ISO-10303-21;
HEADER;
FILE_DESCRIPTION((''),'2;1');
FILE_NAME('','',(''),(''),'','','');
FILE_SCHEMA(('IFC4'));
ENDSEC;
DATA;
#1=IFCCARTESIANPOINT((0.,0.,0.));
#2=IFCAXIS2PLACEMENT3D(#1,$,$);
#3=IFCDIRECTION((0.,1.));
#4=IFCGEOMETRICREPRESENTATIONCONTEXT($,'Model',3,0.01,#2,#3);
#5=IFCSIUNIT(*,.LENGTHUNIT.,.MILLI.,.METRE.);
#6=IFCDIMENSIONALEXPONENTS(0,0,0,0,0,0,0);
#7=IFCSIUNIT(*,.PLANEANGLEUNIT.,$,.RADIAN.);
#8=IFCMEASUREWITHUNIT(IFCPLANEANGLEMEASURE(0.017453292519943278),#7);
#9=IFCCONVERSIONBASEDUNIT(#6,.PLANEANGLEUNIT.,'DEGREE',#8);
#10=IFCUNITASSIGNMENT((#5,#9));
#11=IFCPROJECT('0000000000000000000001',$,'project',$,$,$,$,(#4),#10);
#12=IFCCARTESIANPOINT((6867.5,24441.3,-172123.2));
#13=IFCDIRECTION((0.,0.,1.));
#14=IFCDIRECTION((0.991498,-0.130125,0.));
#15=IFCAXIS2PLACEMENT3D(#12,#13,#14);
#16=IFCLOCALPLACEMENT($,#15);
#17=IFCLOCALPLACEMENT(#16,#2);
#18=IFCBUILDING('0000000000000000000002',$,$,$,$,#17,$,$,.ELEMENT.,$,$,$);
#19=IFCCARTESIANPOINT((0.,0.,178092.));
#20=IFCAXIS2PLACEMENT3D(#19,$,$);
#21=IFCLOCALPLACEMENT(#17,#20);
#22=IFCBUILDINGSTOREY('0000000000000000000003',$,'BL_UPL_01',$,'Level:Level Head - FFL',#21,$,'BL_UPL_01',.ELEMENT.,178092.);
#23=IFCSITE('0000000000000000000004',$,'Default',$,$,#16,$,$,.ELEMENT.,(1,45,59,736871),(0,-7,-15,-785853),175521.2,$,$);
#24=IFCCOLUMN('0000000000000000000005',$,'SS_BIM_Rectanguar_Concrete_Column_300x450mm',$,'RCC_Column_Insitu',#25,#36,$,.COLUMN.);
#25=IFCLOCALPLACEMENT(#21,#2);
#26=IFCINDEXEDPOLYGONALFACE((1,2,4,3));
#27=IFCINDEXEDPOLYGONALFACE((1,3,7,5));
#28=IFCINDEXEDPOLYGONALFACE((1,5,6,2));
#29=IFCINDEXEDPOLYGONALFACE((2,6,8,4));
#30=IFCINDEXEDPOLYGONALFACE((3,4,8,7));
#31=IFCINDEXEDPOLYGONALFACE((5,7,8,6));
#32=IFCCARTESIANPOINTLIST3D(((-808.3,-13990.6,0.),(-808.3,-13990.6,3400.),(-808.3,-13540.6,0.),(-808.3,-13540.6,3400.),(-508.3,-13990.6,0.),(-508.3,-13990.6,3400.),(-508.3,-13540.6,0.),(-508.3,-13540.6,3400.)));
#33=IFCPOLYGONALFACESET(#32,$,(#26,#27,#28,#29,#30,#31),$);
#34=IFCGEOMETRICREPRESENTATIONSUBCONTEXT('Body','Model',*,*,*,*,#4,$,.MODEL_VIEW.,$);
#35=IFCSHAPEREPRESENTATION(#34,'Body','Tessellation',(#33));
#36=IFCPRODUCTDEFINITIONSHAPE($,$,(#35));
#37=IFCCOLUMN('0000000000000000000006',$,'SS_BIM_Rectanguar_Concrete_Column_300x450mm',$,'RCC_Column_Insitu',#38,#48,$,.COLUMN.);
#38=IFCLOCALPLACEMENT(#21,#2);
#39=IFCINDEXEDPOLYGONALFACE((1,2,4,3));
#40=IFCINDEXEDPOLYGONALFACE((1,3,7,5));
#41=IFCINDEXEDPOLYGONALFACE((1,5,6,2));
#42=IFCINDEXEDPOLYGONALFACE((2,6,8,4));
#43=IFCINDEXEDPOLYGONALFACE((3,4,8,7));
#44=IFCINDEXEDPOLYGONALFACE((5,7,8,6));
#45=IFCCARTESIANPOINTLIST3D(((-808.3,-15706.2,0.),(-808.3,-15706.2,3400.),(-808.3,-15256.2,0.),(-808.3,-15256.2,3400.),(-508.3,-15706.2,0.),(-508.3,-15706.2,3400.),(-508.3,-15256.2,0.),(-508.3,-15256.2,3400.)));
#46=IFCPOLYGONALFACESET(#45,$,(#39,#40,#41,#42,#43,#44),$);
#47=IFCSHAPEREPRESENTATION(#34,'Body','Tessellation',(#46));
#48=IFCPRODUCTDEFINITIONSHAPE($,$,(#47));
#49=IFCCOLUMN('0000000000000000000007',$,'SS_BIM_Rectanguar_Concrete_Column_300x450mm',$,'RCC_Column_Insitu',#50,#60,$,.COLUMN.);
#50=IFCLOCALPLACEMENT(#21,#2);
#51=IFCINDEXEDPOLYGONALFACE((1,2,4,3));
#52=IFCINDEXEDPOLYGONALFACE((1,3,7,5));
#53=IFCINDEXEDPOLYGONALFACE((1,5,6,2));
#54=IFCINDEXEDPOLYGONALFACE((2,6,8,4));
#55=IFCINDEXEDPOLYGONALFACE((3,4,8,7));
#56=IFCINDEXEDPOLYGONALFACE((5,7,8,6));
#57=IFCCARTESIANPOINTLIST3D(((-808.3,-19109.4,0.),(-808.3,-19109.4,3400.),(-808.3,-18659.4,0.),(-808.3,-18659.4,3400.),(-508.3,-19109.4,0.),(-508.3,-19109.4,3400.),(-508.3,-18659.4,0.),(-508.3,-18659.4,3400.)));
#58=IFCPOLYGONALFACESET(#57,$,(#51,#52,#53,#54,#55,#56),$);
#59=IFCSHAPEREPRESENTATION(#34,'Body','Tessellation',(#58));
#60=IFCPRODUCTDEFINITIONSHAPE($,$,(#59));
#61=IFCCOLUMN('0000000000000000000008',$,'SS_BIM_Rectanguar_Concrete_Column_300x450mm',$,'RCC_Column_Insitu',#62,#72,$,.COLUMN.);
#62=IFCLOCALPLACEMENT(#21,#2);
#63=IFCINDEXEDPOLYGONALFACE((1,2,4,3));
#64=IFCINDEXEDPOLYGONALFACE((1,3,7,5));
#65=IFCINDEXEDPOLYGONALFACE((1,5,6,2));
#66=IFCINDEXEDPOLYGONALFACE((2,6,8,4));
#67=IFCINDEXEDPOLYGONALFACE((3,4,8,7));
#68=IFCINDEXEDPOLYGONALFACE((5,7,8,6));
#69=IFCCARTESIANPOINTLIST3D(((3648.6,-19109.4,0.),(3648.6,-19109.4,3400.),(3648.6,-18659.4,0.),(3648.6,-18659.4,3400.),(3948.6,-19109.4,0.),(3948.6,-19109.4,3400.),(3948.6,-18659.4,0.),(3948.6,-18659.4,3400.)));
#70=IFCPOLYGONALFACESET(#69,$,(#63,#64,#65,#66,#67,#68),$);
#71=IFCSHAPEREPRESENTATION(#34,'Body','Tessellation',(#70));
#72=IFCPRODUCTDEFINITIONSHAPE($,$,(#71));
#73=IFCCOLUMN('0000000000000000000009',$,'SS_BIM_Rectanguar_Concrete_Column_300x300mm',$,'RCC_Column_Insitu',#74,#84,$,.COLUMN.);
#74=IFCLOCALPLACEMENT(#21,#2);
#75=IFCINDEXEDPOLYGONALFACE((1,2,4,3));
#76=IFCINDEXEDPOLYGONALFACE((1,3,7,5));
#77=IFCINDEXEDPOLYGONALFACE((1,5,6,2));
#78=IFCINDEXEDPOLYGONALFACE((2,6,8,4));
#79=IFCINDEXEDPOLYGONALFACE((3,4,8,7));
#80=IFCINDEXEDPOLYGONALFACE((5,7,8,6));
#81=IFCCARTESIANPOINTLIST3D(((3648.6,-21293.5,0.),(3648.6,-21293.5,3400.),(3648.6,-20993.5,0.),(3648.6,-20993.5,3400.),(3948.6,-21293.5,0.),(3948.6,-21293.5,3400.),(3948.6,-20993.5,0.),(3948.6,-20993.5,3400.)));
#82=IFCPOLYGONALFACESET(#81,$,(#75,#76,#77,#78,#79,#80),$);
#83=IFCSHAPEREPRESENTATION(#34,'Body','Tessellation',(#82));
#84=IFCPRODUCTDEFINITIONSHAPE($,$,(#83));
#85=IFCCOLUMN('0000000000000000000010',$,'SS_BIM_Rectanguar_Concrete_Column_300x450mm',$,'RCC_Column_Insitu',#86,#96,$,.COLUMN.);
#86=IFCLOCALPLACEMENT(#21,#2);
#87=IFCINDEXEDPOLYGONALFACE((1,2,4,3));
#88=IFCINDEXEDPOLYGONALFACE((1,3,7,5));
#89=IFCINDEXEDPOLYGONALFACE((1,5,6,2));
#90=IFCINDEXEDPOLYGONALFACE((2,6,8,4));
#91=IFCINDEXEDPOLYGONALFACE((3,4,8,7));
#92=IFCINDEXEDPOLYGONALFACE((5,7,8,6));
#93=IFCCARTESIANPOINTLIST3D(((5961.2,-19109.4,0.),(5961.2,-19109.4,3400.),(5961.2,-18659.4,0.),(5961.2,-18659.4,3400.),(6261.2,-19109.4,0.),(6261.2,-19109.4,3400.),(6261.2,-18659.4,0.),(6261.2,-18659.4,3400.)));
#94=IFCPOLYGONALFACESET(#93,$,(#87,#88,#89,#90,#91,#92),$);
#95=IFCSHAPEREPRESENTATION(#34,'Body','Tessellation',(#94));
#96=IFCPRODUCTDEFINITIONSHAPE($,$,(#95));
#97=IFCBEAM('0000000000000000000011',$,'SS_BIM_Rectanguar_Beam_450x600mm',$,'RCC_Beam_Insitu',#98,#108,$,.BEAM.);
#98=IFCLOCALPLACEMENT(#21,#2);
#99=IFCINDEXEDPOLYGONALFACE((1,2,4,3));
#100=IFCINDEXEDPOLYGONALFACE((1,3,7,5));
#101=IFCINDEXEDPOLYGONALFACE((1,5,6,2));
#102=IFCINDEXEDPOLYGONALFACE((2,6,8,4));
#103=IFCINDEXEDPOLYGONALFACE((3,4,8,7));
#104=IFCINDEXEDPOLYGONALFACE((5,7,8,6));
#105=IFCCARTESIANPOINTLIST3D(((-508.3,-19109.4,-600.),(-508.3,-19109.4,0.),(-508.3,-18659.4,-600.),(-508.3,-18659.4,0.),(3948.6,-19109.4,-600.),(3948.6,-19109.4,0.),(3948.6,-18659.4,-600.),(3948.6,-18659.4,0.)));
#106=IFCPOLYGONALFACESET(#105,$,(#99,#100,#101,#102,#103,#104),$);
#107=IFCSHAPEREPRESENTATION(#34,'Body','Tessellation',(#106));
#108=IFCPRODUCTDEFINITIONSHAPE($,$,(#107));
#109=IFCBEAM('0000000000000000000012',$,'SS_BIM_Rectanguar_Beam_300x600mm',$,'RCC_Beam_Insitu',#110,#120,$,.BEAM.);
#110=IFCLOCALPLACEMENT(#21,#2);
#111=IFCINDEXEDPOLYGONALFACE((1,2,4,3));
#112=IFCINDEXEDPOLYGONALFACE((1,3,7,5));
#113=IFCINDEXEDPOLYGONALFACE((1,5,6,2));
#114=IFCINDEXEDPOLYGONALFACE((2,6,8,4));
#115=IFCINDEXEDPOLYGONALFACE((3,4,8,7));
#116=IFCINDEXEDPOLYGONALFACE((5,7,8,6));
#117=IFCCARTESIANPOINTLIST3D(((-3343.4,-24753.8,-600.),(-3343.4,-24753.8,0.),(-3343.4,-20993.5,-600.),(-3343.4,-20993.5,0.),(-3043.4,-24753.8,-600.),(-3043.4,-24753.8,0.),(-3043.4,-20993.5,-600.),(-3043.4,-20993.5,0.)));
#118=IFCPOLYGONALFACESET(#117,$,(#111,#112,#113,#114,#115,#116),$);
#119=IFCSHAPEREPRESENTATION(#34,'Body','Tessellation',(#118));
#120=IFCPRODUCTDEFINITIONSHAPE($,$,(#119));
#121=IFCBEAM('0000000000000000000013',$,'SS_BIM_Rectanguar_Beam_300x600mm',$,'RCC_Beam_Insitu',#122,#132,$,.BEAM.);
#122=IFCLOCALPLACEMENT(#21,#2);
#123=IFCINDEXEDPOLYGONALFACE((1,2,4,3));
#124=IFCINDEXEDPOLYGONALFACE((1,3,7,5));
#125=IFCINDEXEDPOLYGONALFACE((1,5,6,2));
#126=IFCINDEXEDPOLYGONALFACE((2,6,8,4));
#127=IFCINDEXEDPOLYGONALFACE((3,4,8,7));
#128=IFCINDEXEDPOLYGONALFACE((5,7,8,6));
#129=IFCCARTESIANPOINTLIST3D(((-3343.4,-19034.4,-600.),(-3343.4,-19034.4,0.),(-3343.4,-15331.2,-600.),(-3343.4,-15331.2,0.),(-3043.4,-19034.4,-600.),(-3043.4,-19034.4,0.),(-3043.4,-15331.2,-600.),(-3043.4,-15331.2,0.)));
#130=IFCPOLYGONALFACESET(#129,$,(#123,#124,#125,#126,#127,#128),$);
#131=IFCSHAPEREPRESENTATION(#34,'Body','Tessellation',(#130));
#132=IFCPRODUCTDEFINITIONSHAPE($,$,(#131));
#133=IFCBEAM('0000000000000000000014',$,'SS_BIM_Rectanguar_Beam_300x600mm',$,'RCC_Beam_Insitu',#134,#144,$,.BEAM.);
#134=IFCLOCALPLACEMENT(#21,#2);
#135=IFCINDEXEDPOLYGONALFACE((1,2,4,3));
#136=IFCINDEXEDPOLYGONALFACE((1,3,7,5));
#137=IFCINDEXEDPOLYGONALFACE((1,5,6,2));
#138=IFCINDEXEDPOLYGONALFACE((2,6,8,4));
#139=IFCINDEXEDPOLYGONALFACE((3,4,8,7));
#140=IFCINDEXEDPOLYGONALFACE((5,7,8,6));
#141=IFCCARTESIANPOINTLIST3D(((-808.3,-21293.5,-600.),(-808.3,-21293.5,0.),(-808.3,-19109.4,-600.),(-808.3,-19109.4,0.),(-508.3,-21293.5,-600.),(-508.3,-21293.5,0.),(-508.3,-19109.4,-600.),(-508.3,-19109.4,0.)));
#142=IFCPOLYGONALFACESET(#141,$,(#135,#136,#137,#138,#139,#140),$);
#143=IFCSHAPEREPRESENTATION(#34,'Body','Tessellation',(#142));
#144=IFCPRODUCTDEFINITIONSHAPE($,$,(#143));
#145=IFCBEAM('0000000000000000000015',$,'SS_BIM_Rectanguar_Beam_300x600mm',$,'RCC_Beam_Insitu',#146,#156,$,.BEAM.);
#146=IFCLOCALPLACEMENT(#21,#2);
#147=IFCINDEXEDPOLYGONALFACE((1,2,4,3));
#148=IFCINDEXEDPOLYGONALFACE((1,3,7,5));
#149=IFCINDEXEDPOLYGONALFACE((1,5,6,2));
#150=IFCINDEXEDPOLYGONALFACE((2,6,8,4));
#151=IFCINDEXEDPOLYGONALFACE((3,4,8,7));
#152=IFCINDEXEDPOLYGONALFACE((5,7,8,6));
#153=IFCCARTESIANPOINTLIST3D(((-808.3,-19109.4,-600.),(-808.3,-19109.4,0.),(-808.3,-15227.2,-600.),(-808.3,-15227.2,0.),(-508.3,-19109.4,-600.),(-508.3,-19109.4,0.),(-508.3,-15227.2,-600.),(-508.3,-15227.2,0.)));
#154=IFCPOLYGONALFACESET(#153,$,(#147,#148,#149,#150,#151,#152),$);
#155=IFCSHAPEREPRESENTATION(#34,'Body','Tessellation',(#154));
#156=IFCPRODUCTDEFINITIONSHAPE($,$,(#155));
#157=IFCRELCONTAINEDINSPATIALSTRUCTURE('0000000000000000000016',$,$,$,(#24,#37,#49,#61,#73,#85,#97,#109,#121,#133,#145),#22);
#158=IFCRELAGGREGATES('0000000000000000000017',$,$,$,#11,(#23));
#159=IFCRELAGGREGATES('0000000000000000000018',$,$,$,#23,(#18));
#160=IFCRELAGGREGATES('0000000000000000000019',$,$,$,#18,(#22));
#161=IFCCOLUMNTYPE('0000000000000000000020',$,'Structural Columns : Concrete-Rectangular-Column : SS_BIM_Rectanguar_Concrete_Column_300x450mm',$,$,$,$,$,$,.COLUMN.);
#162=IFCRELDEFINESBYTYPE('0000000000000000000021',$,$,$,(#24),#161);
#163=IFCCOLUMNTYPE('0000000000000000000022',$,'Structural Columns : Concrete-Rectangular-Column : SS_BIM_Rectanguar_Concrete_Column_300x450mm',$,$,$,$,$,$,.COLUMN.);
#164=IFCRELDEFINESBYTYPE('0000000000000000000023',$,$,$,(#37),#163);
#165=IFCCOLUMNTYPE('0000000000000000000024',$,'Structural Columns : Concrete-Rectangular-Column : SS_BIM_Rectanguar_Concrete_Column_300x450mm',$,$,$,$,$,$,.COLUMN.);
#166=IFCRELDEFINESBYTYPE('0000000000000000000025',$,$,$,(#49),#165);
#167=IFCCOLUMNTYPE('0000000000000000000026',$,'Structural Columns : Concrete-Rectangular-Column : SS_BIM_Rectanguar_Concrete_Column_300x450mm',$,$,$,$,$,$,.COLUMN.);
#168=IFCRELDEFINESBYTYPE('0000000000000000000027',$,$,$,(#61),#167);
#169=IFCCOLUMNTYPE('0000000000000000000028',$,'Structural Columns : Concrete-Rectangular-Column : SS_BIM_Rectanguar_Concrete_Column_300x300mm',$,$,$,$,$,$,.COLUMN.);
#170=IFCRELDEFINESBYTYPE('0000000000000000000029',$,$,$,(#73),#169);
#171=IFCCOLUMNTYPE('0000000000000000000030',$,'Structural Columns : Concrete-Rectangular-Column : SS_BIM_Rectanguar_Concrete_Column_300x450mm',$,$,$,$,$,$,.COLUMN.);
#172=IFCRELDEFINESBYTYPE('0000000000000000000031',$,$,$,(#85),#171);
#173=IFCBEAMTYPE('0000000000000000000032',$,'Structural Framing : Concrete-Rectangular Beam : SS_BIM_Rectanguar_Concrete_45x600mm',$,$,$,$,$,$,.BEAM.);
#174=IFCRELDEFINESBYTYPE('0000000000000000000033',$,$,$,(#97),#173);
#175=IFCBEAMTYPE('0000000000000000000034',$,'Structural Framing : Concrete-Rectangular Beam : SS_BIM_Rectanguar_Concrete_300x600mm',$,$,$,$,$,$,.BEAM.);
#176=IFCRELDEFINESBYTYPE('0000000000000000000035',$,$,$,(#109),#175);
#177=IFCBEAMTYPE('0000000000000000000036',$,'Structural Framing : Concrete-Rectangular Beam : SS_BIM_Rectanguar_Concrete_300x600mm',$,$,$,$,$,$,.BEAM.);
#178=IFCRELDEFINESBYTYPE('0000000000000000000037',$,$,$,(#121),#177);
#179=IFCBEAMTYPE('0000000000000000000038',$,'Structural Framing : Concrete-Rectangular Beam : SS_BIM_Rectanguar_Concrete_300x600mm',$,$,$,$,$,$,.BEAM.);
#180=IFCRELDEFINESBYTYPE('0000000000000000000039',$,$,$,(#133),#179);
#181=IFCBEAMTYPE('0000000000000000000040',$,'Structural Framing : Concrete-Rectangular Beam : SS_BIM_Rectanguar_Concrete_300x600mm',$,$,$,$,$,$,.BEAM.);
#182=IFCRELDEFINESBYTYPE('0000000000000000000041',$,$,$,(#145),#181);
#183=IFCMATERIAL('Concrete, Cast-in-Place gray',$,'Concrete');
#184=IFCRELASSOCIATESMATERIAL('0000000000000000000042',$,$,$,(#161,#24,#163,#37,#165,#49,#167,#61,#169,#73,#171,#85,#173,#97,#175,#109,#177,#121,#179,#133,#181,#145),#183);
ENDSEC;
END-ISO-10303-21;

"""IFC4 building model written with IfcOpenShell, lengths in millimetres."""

from ifc_helpers import new_model, entity, si_unit, converted_unit, direction, frame, origin, place, context, subcontext, project, spatial, indexed_curve, outline, extrude, source, transform, mapped, material, type_object, type_shapes, element, save


model = new_model("IFC4")

# Units and contexts
model_context = context("Model", 3, precision=0.01, world=origin(), true_north=direction((0.0, 1.0)))
body_context = subcontext(model_context, "Body", "Model", "MODEL_VIEW")
ifc_project = project(units=[si_unit("LENGTHUNIT", "METRE", prefix="MILLI"), converted_unit("PLANEANGLEUNIT", "DEGREE", entity("IfcPlaneAngleMeasure", 0.017453292519943278), si_unit("PLANEANGLEUNIT", "RADIAN"), dimensions=[0, 0, 0, 0, 0, 0, 0])], contexts=[model_context])

# Site, building, storey
site_placement = place(None, frame((6867.5, 24441.3, -172123.2), z_axis=(0.0, 0.0, 1.0), x_axis=(0.991498, -0.130125, 0.0)))
site = spatial("IfcSite", under=ifc_project, at=site_placement, Name="Default", CompositionType="ELEMENT", RefLatitude=(1, 45, 59, 736871), RefLongitude=(0, -7, -15, -785853), RefElevation=175521.2)
building_placement = place(site_placement, origin())
building = spatial("IfcBuilding", under=site, at=building_placement, CompositionType="ELEMENT")
storey_placement = place(building_placement, frame((0.0, 0.0, 178092.0)))
storey = spatial("IfcBuildingStorey", under=building, at=storey_placement, Name="BL_UPL_01", ObjectType="Level:Level Head - FFL", LongName="BL_UPL_01", CompositionType="ELEMENT", Elevation=178092.0)

# Columns
ifc_material_1 = material(Name="Concrete, Cast-in-Place gray", Category="Concrete")
column_type_1 = type_object("IfcColumnType", Name="Structural Columns : Concrete-Rectangular-Column : SS_BIM_Rectanguar_Concrete_Column_300x450mm", PredefinedType="COLUMN", material=ifc_material_1)
shared_shape_1 = source(origin(), body_context, "Body", "SweptSolid", [
    extrude(outline(indexed_curve([(-150.0, -225.0), (150.0, -225.0), (150.0, 225.0), (-150.0, 225.0), (-150.0, -225.0)], self_intersect=False)), frame((-658.3, -13765.6, 178092.0), z_axis=(0.0, 0.0, 1.0), x_axis=(-1.0, 0.0, 0.0)), (0.0, 0.0, 1.0), 3400.0),
])
type_shapes(column_type_1, [shared_shape_1])
column_1_placement = place(storey_placement, frame((0.0, 0.0, -178092.0)))
element("IfcColumn", 1, at=column_1_placement, inside=storey, type_object=column_type_1, material=ifc_material_1, Name="SS_BIM_Rectanguar_Concrete_Column_300x450mm", ObjectType="RCC_Column_Insitu", PredefinedType="COLUMN", context=body_context, shape_type="MappedRepresentation", body=[
    mapped(shared_shape_1, transform((0.0, 0.0, 0.0), scale=1.0)),
])
column_type_2 = type_object("IfcColumnType", Name="Structural Columns : Concrete-Rectangular-Column : SS_BIM_Rectanguar_Concrete_Column_300x450mm", PredefinedType="COLUMN", material=ifc_material_1)
shared_shape_2 = source(origin(), body_context, "Body", "SweptSolid", [
    extrude(outline(indexed_curve([(-150.0, -225.0), (150.0, -225.0), (150.0, 225.0), (-150.0, 225.0), (-150.0, -225.0)], self_intersect=False)), frame((-658.3, -15481.2, 178092.0), z_axis=(0.0, 0.0, 1.0), x_axis=(-1.0, 0.0, 0.0)), (0.0, 0.0, 1.0), 3400.0),
])
type_shapes(column_type_2, [shared_shape_2])
column_2_placement = place(storey_placement, frame((0.0, 0.0, -178092.0)))
element("IfcColumn", 2, at=column_2_placement, inside=storey, type_object=column_type_2, material=ifc_material_1, Name="SS_BIM_Rectanguar_Concrete_Column_300x450mm", ObjectType="RCC_Column_Insitu", PredefinedType="COLUMN", context=body_context, shape_type="MappedRepresentation", body=[
    mapped(shared_shape_2, transform((0.0, 0.0, 0.0), scale=1.0)),
])
column_type_3 = type_object("IfcColumnType", Name="Structural Columns : Concrete-Rectangular-Column : SS_BIM_Rectanguar_Concrete_Column_300x450mm", PredefinedType="COLUMN", material=ifc_material_1)
shared_shape_3 = source(origin(), body_context, "Body", "SweptSolid", [
    extrude(outline(indexed_curve([(-150.0, -225.0), (150.0, -225.0), (150.0, 225.0), (-150.0, 225.0), (-150.0, -225.0)], self_intersect=False)), frame((-658.3, -18884.4, 178092.0), z_axis=(0.0, 0.0, 1.0), x_axis=(-1.0, 0.0, 0.0)), (0.0, 0.0, 1.0), 3400.0),
])
type_shapes(column_type_3, [shared_shape_3])
column_3_placement = place(storey_placement, frame((0.0, 0.0, -178092.0)))
element("IfcColumn", 3, at=column_3_placement, inside=storey, type_object=column_type_3, material=ifc_material_1, Name="SS_BIM_Rectanguar_Concrete_Column_300x450mm", ObjectType="RCC_Column_Insitu", PredefinedType="COLUMN", context=body_context, shape_type="MappedRepresentation", body=[
    mapped(shared_shape_3, transform((0.0, 0.0, 0.0), scale=1.0)),
])
column_type_4 = type_object("IfcColumnType", Name="Structural Columns : Concrete-Rectangular-Column : SS_BIM_Rectanguar_Concrete_Column_300x450mm", PredefinedType="COLUMN", material=ifc_material_1)
shared_shape_4 = source(origin(), body_context, "Body", "SweptSolid", [
    extrude(outline(indexed_curve([(-150.0, -225.0), (150.0, -225.0), (150.0, 225.0), (-150.0, 225.0), (-150.0, -225.0)], self_intersect=False)), frame((3798.6, -18884.4, 178092.0), z_axis=(0.0, 0.0, 1.0), x_axis=(-1.0, 0.0, 0.0)), (0.0, 0.0, 1.0), 3400.0),
])
type_shapes(column_type_4, [shared_shape_4])
column_4_placement = place(storey_placement, frame((0.0, 0.0, -178092.0)))
element("IfcColumn", 4, at=column_4_placement, inside=storey, type_object=column_type_4, material=ifc_material_1, Name="SS_BIM_Rectanguar_Concrete_Column_300x450mm", ObjectType="RCC_Column_Insitu", PredefinedType="COLUMN", context=body_context, shape_type="MappedRepresentation", body=[
    mapped(shared_shape_4, transform((0.0, 0.0, 0.0), scale=1.0)),
])
column_type_5 = type_object("IfcColumnType", Name="Structural Columns : Concrete-Rectangular-Column : SS_BIM_Rectanguar_Concrete_Column_300x300mm", PredefinedType="COLUMN", material=ifc_material_1)
shared_shape_5 = source(origin(), body_context, "Body", "SweptSolid", [
    extrude(outline(indexed_curve([(-150.0, -150.0), (150.0, -150.0), (150.0, 150.0), (-150.0, 150.0), (-150.0, -150.0)], self_intersect=False)), frame((3798.6, -21143.5, 178092.0), z_axis=(0.0, 0.0, 1.0), x_axis=(-1.0, 0.0, 0.0)), (0.0, 0.0, 1.0), 3400.0),
])
type_shapes(column_type_5, [shared_shape_5])
column_5_placement = place(storey_placement, frame((0.0, 0.0, -178092.0)))
element("IfcColumn", 5, at=column_5_placement, inside=storey, type_object=column_type_5, material=ifc_material_1, Name="SS_BIM_Rectanguar_Concrete_Column_300x300mm", ObjectType="RCC_Column_Insitu", PredefinedType="COLUMN", context=body_context, shape_type="MappedRepresentation", body=[
    mapped(shared_shape_5, transform((0.0, 0.0, 0.0), scale=1.0)),
])
column_type_6 = type_object("IfcColumnType", Name="Structural Columns : Concrete-Rectangular-Column : SS_BIM_Rectanguar_Concrete_Column_300x450mm", PredefinedType="COLUMN", material=ifc_material_1)
shared_shape_6 = source(origin(), body_context, "Body", "SweptSolid", [
    extrude(outline(indexed_curve([(-150.0, -225.0), (150.0, -225.0), (150.0, 225.0), (-150.0, 225.0), (-150.0, -225.0)], self_intersect=False)), frame((6111.2, -18884.4, 178092.0), z_axis=(0.0, 0.0, 1.0), x_axis=(-1.0, 0.0, 0.0)), (0.0, 0.0, 1.0), 3400.0),
])
type_shapes(column_type_6, [shared_shape_6])
column_6_placement = place(storey_placement, frame((0.0, 0.0, -178092.0)))
element("IfcColumn", 6, at=column_6_placement, inside=storey, type_object=column_type_6, material=ifc_material_1, Name="SS_BIM_Rectanguar_Concrete_Column_300x450mm", ObjectType="RCC_Column_Insitu", PredefinedType="COLUMN", context=body_context, shape_type="MappedRepresentation", body=[
    mapped(shared_shape_6, transform((0.0, 0.0, 0.0), scale=1.0)),
])

# Beams
beam_type_1 = type_object("IfcBeamType", Name="Structural Framing : Concrete-Rectangular Beam : SS_BIM_Rectanguar_Concrete_45x600mm", PredefinedType="BEAM", material=ifc_material_1)
shared_shape_7 = source(origin(), body_context, "Body", "SweptSolid", [
    extrude(outline(indexed_curve([(-300.0, -225.0), (300.0, -225.0), (300.0, 225.0), (-300.0, 225.0), (-300.0, -225.0)], self_intersect=False)), frame((-508.3, -18884.4, 177792.0), z_axis=(1.0, 0.0, 0.0), x_axis=(0.0, 0.0, -1.0)), (0.0, 0.0, 1.0), 4456.9),
])
type_shapes(beam_type_1, [shared_shape_7])
beam_1_placement = place(storey_placement, frame((0.0, 0.0, -178092.0)))
element("IfcBeam", 7, at=beam_1_placement, inside=storey, type_object=beam_type_1, material=ifc_material_1, Name="SS_BIM_Rectanguar_Beam_450x600mm", ObjectType="RCC_Beam_Insitu", PredefinedType="BEAM", context=body_context, shape_type="MappedRepresentation", body=[
    mapped(shared_shape_7, transform((0.0, 0.0, 0.0), scale=1.0)),
])
beam_type_2 = type_object("IfcBeamType", Name="Structural Framing : Concrete-Rectangular Beam : SS_BIM_Rectanguar_Concrete_300x600mm", PredefinedType="BEAM", material=ifc_material_1)
shared_shape_8 = source(origin(), body_context, "Body", "SweptSolid", [
    extrude(outline(indexed_curve([(-150.0, -300.0), (150.0, -300.0), (150.0, 300.0), (-150.0, 300.0), (-150.0, -300.0)], self_intersect=False)), frame((-3193.4, -24753.8, 177792.0), z_axis=(0.0, 1.0, 0.0), x_axis=(-1.0, 0.0, 0.0)), (0.0, 0.0, 1.0), 3760.3),
])
type_shapes(beam_type_2, [shared_shape_8])
beam_2_placement = place(storey_placement, frame((0.0, 0.0, -178092.0)))
element("IfcBeam", 8, at=beam_2_placement, inside=storey, type_object=beam_type_2, material=ifc_material_1, Name="SS_BIM_Rectanguar_Beam_300x600mm", ObjectType="RCC_Beam_Insitu", PredefinedType="BEAM", context=body_context, shape_type="MappedRepresentation", body=[
    mapped(shared_shape_8, transform((0.0, 0.0, 0.0), scale=1.0)),
])
beam_type_3 = type_object("IfcBeamType", Name="Structural Framing : Concrete-Rectangular Beam : SS_BIM_Rectanguar_Concrete_300x600mm", PredefinedType="BEAM", material=ifc_material_1)
shared_shape_9 = source(origin(), body_context, "Body", "SweptSolid", [
    extrude(outline(indexed_curve([(-150.0, -300.0), (150.0, -300.0), (150.0, 300.0), (-150.0, 300.0), (-150.0, -300.0)], self_intersect=False)), frame((-3193.4, -19034.4, 177792.0), z_axis=(0.0, 1.0, 0.0), x_axis=(-1.0, 0.0, 0.0)), (0.0, 0.0, 1.0), 3703.2),
])
type_shapes(beam_type_3, [shared_shape_9])
beam_3_placement = place(storey_placement, frame((0.0, 0.0, -178092.0)))
element("IfcBeam", 9, at=beam_3_placement, inside=storey, type_object=beam_type_3, material=ifc_material_1, Name="SS_BIM_Rectanguar_Beam_300x600mm", ObjectType="RCC_Beam_Insitu", PredefinedType="BEAM", context=body_context, shape_type="MappedRepresentation", body=[
    mapped(shared_shape_9, transform((0.0, 0.0, 0.0), scale=1.0)),
])
beam_type_4 = type_object("IfcBeamType", Name="Structural Framing : Concrete-Rectangular Beam : SS_BIM_Rectanguar_Concrete_300x600mm", PredefinedType="BEAM", material=ifc_material_1)
shared_shape_10 = source(origin(), body_context, "Body", "SweptSolid", [
    extrude(outline(indexed_curve([(-150.0, -300.0), (150.0, -300.0), (150.0, 300.0), (-150.0, 300.0), (-150.0, -300.0)], self_intersect=False)), frame((-658.3, -21293.5, 177792.0), z_axis=(0.0, 1.0, 0.0), x_axis=(-1.0, 0.0, 0.0)), (0.0, 0.0, 1.0), 2184.1),
])
type_shapes(beam_type_4, [shared_shape_10])
beam_4_placement = place(storey_placement, frame((0.0, 0.0, -178092.0)))
element("IfcBeam", 10, at=beam_4_placement, inside=storey, type_object=beam_type_4, material=ifc_material_1, Name="SS_BIM_Rectanguar_Beam_300x600mm", ObjectType="RCC_Beam_Insitu", PredefinedType="BEAM", context=body_context, shape_type="MappedRepresentation", body=[
    mapped(shared_shape_10, transform((0.0, 0.0, 0.0), scale=1.0)),
])
beam_type_5 = type_object("IfcBeamType", Name="Structural Framing : Concrete-Rectangular Beam : SS_BIM_Rectanguar_Concrete_300x600mm", PredefinedType="BEAM", material=ifc_material_1)
shared_shape_11 = source(origin(), body_context, "Body", "SweptSolid", [
    extrude(outline(indexed_curve([(-150.0, -300.0), (150.0, -300.0), (150.0, 300.0), (-150.0, 300.0), (-150.0, -300.0)], self_intersect=False)), frame((-658.3, -19109.4, 177792.0), z_axis=(0.0, 1.0, 0.0), x_axis=(-1.0, 0.0, 0.0)), (0.0, 0.0, 1.0), 3882.2),
])
type_shapes(beam_type_5, [shared_shape_11])
beam_5_placement = place(storey_placement, frame((0.0, 0.0, -178092.0)))
element("IfcBeam", 11, at=beam_5_placement, inside=storey, type_object=beam_type_5, material=ifc_material_1, Name="SS_BIM_Rectanguar_Beam_300x600mm", ObjectType="RCC_Beam_Insitu", PredefinedType="BEAM", context=body_context, shape_type="MappedRepresentation", body=[
    mapped(shared_shape_11, transform((0.0, 0.0, 0.0), scale=1.0)),
])

save(model, "model.ifc")
